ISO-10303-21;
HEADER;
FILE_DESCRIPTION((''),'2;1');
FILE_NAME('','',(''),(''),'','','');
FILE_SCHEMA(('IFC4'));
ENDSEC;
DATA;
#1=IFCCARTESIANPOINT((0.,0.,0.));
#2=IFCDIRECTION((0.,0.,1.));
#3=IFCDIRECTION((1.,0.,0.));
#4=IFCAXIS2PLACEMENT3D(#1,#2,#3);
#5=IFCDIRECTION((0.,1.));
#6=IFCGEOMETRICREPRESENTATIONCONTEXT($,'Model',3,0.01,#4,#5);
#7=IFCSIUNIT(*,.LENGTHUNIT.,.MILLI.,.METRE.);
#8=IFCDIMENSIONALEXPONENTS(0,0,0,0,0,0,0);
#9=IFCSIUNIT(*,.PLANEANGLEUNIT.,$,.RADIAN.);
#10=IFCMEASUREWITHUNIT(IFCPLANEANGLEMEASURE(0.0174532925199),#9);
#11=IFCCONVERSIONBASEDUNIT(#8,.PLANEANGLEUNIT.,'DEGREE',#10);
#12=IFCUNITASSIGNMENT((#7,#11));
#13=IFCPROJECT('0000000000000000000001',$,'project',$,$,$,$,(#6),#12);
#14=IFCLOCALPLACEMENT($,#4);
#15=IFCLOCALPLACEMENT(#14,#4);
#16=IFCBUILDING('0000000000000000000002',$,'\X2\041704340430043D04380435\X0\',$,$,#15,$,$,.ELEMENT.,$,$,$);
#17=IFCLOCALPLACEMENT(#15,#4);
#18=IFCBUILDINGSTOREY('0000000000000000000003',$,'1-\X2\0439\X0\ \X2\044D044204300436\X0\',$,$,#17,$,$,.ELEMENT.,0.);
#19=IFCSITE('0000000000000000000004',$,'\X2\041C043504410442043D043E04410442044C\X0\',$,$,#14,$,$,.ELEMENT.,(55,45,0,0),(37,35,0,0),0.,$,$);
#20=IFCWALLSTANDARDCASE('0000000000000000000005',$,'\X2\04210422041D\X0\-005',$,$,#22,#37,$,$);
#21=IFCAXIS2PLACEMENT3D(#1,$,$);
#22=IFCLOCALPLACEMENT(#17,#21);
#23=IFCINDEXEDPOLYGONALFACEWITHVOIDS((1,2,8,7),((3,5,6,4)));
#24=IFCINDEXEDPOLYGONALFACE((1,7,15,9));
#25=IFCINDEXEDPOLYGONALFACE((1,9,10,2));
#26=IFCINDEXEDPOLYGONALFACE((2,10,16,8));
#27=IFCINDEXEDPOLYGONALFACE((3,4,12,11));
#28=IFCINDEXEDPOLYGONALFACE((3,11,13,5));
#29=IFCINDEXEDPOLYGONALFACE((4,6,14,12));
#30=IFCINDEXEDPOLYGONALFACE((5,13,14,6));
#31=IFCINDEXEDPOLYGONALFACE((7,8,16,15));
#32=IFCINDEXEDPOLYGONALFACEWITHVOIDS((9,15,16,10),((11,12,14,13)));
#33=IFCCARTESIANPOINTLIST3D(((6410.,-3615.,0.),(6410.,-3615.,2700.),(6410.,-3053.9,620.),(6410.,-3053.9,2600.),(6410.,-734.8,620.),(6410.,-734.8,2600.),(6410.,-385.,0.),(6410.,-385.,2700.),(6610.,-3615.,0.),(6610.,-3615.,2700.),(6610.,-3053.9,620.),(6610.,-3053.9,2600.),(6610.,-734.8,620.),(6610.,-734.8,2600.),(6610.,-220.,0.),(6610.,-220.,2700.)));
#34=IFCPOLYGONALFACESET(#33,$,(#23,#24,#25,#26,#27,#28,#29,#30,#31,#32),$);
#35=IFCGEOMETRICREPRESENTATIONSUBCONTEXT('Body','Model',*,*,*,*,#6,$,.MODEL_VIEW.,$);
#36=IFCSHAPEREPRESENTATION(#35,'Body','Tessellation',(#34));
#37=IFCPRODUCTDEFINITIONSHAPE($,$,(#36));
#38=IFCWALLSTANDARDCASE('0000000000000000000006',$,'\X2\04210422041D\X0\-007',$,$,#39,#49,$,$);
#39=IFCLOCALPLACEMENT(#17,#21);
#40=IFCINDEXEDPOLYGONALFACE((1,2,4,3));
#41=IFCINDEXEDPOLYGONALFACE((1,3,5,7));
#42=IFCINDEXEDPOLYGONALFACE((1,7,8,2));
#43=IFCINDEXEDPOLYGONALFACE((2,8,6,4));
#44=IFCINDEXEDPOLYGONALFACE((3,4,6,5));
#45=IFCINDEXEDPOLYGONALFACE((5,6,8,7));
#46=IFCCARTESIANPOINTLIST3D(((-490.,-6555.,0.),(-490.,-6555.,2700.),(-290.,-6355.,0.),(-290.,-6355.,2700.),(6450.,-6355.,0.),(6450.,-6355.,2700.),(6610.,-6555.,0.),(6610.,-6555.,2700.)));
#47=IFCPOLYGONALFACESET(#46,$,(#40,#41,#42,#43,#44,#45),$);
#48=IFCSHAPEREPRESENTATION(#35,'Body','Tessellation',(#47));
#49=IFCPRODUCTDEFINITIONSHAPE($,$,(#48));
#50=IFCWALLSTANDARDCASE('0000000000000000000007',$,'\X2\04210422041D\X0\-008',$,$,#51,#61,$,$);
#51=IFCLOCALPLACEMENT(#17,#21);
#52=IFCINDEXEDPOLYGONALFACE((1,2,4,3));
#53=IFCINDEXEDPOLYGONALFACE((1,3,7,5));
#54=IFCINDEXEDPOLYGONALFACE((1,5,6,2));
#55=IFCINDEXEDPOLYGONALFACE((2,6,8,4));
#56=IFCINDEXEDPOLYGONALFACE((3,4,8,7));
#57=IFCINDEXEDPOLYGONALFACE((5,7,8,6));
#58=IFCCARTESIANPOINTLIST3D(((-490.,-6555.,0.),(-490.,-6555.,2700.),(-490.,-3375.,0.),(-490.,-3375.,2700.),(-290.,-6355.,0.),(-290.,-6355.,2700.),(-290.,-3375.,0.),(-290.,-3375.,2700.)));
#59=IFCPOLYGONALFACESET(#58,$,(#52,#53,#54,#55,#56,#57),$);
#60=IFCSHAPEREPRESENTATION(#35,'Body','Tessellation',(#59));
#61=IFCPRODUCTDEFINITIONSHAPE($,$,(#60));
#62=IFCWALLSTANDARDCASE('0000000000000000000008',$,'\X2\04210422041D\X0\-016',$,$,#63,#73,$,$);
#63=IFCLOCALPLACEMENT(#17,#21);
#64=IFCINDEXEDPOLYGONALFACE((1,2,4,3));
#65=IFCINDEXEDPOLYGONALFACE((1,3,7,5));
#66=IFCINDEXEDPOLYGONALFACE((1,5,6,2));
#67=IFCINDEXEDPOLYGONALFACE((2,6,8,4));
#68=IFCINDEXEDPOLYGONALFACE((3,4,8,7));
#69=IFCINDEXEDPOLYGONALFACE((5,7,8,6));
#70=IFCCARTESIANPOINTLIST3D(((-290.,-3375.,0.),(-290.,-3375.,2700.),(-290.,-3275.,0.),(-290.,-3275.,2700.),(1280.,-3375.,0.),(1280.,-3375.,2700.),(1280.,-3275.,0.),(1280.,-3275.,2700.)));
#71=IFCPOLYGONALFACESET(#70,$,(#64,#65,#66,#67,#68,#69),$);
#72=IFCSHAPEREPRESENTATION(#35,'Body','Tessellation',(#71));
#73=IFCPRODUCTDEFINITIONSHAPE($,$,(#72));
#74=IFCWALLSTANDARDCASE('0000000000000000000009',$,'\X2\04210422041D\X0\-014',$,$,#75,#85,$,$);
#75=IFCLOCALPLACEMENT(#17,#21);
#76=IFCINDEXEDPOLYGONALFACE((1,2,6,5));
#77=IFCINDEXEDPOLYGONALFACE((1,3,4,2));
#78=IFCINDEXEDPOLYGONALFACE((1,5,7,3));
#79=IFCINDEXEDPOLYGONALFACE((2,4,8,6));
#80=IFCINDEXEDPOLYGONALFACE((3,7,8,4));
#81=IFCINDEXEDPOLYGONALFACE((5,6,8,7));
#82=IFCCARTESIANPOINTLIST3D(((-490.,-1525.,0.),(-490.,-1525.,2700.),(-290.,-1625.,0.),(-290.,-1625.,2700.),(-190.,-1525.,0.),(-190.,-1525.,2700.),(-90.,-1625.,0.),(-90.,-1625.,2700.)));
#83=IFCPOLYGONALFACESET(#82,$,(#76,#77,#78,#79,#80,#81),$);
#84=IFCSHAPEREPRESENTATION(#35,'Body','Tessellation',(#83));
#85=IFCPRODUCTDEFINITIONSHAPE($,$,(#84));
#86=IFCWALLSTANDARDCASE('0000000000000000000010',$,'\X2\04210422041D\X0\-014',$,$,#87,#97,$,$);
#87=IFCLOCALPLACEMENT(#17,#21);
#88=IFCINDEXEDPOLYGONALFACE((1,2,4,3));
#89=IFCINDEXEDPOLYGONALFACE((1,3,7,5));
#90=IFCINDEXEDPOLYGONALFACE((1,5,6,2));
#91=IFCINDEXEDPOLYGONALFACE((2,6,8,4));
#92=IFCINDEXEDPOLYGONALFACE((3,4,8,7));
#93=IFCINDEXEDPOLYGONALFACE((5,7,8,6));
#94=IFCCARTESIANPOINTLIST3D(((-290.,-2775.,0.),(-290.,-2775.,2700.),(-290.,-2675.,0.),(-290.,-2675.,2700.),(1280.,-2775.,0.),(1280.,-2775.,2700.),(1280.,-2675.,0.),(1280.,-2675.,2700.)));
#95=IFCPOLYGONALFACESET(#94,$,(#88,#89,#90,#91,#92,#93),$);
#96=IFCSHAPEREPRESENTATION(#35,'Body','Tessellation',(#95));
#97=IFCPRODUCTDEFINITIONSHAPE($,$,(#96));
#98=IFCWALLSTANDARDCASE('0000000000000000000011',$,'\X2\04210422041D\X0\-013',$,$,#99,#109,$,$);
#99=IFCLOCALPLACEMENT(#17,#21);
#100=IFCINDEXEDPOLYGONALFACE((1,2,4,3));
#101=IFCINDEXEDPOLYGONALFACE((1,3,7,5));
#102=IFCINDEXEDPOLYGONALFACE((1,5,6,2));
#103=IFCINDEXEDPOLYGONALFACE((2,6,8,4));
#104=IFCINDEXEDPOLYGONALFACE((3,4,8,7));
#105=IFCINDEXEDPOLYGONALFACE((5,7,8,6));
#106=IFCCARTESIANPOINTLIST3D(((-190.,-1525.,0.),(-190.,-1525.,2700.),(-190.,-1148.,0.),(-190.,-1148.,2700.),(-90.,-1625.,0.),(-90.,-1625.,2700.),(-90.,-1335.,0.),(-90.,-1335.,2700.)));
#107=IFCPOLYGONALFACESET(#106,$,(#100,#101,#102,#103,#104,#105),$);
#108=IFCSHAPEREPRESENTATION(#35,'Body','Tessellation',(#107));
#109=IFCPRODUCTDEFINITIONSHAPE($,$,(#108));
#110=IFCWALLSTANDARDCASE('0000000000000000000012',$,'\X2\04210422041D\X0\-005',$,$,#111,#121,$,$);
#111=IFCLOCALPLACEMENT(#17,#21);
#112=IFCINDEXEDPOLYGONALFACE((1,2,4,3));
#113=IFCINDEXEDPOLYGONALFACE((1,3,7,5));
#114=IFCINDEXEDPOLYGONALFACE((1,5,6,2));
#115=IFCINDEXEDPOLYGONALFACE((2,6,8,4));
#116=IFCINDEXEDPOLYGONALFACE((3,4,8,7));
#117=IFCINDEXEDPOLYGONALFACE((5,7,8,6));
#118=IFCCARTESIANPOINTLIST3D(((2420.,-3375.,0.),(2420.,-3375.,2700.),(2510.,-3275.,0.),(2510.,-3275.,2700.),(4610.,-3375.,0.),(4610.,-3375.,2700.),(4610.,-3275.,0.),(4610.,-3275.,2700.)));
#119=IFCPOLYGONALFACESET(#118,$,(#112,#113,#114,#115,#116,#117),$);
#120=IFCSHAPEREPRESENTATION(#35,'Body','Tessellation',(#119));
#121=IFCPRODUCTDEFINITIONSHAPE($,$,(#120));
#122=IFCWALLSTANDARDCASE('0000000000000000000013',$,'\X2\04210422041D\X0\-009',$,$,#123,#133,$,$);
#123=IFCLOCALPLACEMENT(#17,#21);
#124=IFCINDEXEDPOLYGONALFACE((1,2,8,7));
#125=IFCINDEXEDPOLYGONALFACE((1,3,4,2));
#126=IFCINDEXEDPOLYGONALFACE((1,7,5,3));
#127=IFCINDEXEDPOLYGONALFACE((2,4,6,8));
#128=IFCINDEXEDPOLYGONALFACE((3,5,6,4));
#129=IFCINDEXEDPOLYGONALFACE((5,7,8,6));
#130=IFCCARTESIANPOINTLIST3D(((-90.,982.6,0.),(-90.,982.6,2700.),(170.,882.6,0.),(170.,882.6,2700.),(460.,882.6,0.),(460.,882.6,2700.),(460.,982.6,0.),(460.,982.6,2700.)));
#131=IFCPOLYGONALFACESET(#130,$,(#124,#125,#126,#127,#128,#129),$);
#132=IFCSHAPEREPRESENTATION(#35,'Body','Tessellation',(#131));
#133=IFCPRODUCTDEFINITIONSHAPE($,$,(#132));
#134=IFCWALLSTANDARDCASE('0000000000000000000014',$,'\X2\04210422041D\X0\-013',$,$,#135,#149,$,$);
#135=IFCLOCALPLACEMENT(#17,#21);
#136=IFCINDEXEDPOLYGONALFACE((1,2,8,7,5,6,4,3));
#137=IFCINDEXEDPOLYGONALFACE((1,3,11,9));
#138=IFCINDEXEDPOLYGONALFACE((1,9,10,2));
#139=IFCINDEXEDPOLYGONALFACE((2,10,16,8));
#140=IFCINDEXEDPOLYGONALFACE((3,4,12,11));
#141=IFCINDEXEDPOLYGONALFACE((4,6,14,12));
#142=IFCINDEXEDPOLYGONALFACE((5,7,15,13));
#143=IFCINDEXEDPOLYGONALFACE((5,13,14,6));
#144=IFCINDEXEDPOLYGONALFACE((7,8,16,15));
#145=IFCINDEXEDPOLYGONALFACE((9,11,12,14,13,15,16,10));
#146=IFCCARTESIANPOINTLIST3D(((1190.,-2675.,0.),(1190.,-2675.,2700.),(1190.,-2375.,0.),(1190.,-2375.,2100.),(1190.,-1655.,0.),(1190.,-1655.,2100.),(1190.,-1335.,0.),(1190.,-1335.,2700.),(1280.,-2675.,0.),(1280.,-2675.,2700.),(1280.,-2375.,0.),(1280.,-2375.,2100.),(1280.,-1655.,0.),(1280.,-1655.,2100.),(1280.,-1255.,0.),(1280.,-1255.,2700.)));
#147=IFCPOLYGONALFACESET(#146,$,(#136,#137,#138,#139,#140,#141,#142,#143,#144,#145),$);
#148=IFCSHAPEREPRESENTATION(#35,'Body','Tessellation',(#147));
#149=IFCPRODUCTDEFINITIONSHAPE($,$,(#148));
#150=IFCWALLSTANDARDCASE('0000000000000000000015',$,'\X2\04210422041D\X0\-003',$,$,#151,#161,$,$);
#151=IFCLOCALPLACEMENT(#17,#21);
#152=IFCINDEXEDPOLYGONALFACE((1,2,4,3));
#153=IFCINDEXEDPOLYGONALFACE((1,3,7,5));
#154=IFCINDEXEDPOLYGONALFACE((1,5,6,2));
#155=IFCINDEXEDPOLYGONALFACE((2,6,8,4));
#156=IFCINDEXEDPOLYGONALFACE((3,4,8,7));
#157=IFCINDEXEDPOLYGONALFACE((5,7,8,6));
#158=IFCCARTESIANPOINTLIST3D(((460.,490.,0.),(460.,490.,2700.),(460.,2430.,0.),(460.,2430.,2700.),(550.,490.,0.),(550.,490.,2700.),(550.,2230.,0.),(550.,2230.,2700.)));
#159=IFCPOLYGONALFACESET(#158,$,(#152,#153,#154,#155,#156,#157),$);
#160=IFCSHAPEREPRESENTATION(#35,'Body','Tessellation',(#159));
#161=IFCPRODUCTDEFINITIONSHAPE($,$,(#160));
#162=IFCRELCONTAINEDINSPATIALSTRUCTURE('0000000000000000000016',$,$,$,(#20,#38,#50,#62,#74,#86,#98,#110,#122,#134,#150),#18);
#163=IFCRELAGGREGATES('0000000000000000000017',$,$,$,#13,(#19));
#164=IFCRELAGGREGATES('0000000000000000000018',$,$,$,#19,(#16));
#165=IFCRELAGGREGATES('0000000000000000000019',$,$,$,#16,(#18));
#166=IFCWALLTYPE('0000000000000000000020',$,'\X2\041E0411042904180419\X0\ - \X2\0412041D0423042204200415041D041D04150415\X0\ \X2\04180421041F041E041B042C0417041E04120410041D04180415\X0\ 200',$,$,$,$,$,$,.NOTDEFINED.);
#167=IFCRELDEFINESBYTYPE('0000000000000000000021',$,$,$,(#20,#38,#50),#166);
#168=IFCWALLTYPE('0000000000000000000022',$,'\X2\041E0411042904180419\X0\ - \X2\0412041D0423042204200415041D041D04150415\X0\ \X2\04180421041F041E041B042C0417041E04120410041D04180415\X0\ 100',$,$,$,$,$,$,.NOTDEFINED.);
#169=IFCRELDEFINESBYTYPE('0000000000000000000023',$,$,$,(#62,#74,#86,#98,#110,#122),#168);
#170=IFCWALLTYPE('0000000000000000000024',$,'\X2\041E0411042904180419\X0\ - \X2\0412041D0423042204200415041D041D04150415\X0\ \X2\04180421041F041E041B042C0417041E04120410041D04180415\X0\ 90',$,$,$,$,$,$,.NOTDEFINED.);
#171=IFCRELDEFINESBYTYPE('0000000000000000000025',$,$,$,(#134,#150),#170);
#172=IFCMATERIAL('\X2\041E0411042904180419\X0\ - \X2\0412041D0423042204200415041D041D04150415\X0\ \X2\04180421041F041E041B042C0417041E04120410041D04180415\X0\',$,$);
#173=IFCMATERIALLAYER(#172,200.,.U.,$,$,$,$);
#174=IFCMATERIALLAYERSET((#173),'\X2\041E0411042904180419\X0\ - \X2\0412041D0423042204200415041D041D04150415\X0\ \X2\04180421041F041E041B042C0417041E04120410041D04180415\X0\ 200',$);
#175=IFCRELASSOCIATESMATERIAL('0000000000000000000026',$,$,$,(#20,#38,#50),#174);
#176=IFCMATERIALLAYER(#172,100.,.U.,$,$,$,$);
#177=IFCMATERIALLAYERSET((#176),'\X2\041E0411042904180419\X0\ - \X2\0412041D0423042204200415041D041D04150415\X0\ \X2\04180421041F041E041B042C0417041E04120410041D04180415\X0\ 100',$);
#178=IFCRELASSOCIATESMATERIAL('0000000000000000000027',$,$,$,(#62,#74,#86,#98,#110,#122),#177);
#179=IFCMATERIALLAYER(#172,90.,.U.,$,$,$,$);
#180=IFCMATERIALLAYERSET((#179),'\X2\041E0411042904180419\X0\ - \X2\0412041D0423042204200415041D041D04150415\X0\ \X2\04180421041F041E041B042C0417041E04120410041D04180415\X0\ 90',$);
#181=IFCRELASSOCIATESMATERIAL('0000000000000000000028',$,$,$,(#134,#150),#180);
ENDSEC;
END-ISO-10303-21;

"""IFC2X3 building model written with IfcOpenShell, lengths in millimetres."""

from ifc_helpers import new_model, entity, si_unit, converted_unit, direction, frame, origin_with_axes, origin_2d_with_axis, place, context, subcontext, project, spatial, polyline, rectangle, outline, extrude, material, layer, layer_set, layer_usage, type_object, element, save


model = new_model("IFC2X3")

# Units and contexts
model_context = context("Model", 3, precision=0.01, world=origin_with_axes(), true_north=direction((0.0, 1.0)))
body_context = subcontext(model_context, "Body", "Model", "MODEL_VIEW")
ifc_project = project(units=[si_unit("LENGTHUNIT", "METRE", prefix="MILLI"), converted_unit("PLANEANGLEUNIT", "DEGREE", entity("IfcPlaneAngleMeasure", 0.0174532925199), si_unit("PLANEANGLEUNIT", "RADIAN"), dimensions=[0, 0, 0, 0, 0, 0, 0])], contexts=[model_context])

# Site, building, storey
site_placement = place(None, origin_with_axes())
site = spatial("IfcSite", under=ifc_project, at=site_placement, Name="Местность", CompositionType="ELEMENT", RefLatitude=(55, 45, 0, 0), RefLongitude=(37, 35, 0, 0), RefElevation=0.0)
building_placement = place(site_placement, origin_with_axes())
building = spatial("IfcBuilding", under=site, at=building_placement, Name="Здание", CompositionType="ELEMENT")
storey_placement = place(building_placement, origin_with_axes())
storey = spatial("IfcBuildingStorey", under=building, at=storey_placement, Name="1-й этаж", CompositionType="ELEMENT", Elevation=0.0)

# Shared definitions
ifc_material = material(Name="ОБЩИЙ - ВНУТРЕННЕЕ ИСПОЛЬЗОВАНИЕ")

# Shared definitions
ifc_layer_1 = layer(ifc_material, 200.0, ventilated="UNKNOWN")
ifc_layer_set_1 = layer_set([ifc_layer_1], Name="ОБЩИЙ - ВНУТРЕННЕЕ ИСПОЛЬЗОВАНИЕ 200")
wall_type_1 = type_object("IfcWallType", Name="ОБЩИЙ - ВНУТРЕННЕЕ ИСПОЛЬЗОВАНИЕ 200", PredefinedType="NOTDEFINED")

# Wall, opening
ifc_layer_usage_1 = layer_usage(ifc_layer_set_1, "AXIS2", "POSITIVE", -200.0)
wall_1_placement = place(storey_placement, frame((6610.0, -220.0, 0.0), z_axis=(0.0, 0.0, 1.0), x_axis=(0.0, -1.0, 0.0)))
wall_1 = element("IfcWallStandardCase", 1, at=wall_1_placement, inside=storey, type_object=wall_type_1, material=ifc_layer_usage_1, Name="СТН-005", context=body_context, shape_type="SweptSolid", body=[
    extrude(outline(polyline([(165.0, -200.0), (3395.0, -200.0), (3395.0, 0.0), (0.0, 0.0), (165.0, -200.0)])), origin_with_axes(), (0.0, 0.0, 1.0), 2700.0),
])
opening_1_placement = place(wall_1_placement, frame((1674.3, 0.0, 620.0), z_axis=(0.0, 0.0, 1.0), x_axis=(1.0, 0.0, 0.0)))
element("IfcOpeningElement", 2, at=opening_1_placement, cuts=wall_1, context=body_context, shape_type="SweptSolid", body=[
    extrude(rectangle(XDim=2319.2, YDim=1980.0, at=origin_2d_with_axis()), frame((0.0, -200.0, 990.0), z_axis=(0.0, -1.0, 0.0), x_axis=(1.0, 0.0, 0.0)), (0.0, 0.0, -1.0), 600.0),
])

# Walls
ifc_layer_usage_2 = layer_usage(ifc_layer_set_1, "AXIS2", "POSITIVE", -200.0)
wall_2_placement = place(storey_placement, frame((6610.0, -6555.0, 0.0), z_axis=(0.0, 0.0, 1.0), x_axis=(-1.0, 0.0, 0.0)))
element("IfcWallStandardCase", 3, at=wall_2_placement, inside=storey, type_object=wall_type_1, material=ifc_layer_usage_2, Name="СТН-007", context=body_context, shape_type="SweptSolid", body=[
    extrude(outline(polyline([(160.0, -200.0), (6900.0, -200.0), (7100.0, 0.0), (0.0, 0.0), (160.0, -200.0)])), origin_with_axes(), (0.0, 0.0, 1.0), 2700.0),
])
ifc_layer_usage_3 = layer_usage(ifc_layer_set_1, "AXIS2", "POSITIVE", -200.0)
wall_3_placement = place(storey_placement, frame((-490.0, -6555.0, 0.0), z_axis=(0.0, 0.0, 1.0), x_axis=(0.0, 1.0, 0.0)))
element("IfcWallStandardCase", 4, at=wall_3_placement, inside=storey, type_object=wall_type_1, material=ifc_layer_usage_3, Name="СТН-008", context=body_context, shape_type="SweptSolid", body=[
    extrude(outline(polyline([(200.0, -200.0), (3180.0, -200.0), (3180.0, 0.0), (0.0, 0.0), (200.0, -200.0)])), origin_with_axes(), (0.0, 0.0, 1.0), 2700.0),
])
ifc_layer_2 = layer(ifc_material, 100.0, ventilated="UNKNOWN")
ifc_layer_set_2 = layer_set([ifc_layer_2], Name="ОБЩИЙ - ВНУТРЕННЕЕ ИСПОЛЬЗОВАНИЕ 100")
ifc_layer_usage_4 = layer_usage(ifc_layer_set_2, "AXIS2", "POSITIVE", -100.0)
wall_type_2 = type_object("IfcWallType", Name="ОБЩИЙ - ВНУТРЕННЕЕ ИСПОЛЬЗОВАНИЕ 100", PredefinedType="NOTDEFINED")
wall_4_placement = place(storey_placement, frame((1280.0, -3375.0, 0.0), z_axis=(0.0, 0.0, 1.0), x_axis=(-1.0, 0.0, 0.0)))
element("IfcWallStandardCase", 5, at=wall_4_placement, inside=storey, type_object=wall_type_2, material=ifc_layer_usage_4, Name="СТН-016", context=body_context, shape_type="SweptSolid", body=[
    extrude(outline(polyline([(0.0, -100.0), (1570.0, -100.0), (1570.0, 0.0), (0.0, 0.0), (0.0, -100.0)])), origin_with_axes(), (0.0, 0.0, 1.0), 2700.0),
])
ifc_layer_usage_5 = layer_usage(ifc_layer_set_2, "AXIS2", "POSITIVE", 0.0)
wall_5_placement = place(storey_placement, frame((-190.0, -1525.0, 0.0), z_axis=(0.0, 0.0, 1.0), x_axis=(-1.0, 0.0, 0.0)))
element("IfcWallStandardCase", 6, at=wall_5_placement, inside=storey, type_object=wall_type_2, material=ifc_layer_usage_5, Name="СТН-014", context=body_context, shape_type="SweptSolid", body=[
    extrude(outline(polyline([(0.0, 0.0), (300.0, 0.0), (100.0, 100.0), (-100.0, 100.0), (0.0, 0.0)])), origin_with_axes(), (0.0, 0.0, 1.0), 2700.0),
])
ifc_layer_usage_6 = layer_usage(ifc_layer_set_2, "AXIS2", "POSITIVE", 0.0)
wall_6_placement = place(storey_placement, frame((1280.0, -2675.0, 0.0), z_axis=(0.0, 0.0, 1.0), x_axis=(-1.0, 0.0, 0.0)))
element("IfcWallStandardCase", 7, at=wall_6_placement, inside=storey, type_object=wall_type_2, material=ifc_layer_usage_6, Name="СТН-014", context=body_context, shape_type="SweptSolid", body=[
    extrude(outline(polyline([(0.0, 0.0), (1570.0, 0.0), (1570.0, 100.0), (0.0, 100.0), (0.0, 0.0)])), origin_with_axes(), (0.0, 0.0, 1.0), 2700.0),
])
ifc_layer_usage_7 = layer_usage(ifc_layer_set_2, "AXIS2", "POSITIVE", 0.0)
wall_7_placement = place(storey_placement, frame((-190.0, -1335.0, 0.0), z_axis=(0.0, 0.0, 1.0), x_axis=(0.0, -1.0, 0.0)))
element("IfcWallStandardCase", 8, at=wall_7_placement, inside=storey, type_object=wall_type_2, material=ifc_layer_usage_7, Name="СТН-013", context=body_context, shape_type="SweptSolid", body=[
    extrude(outline(polyline([(-187.0, 0.0), (190.0, 0.0), (290.0, 100.0), (0.0, 100.0), (-187.0, 0.0)])), origin_with_axes(), (0.0, 0.0, 1.0), 2700.0),
])
ifc_layer_usage_8 = layer_usage(ifc_layer_set_2, "AXIS2", "POSITIVE", -100.0)
wall_8_placement = place(storey_placement, frame((2510.0, -3275.0, 0.0), z_axis=(0.0, 0.0, 1.0), x_axis=(1.0, 0.0, 0.0)))
element("IfcWallStandardCase", 9, at=wall_8_placement, inside=storey, type_object=wall_type_2, material=ifc_layer_usage_8, Name="СТН-005", context=body_context, shape_type="SweptSolid", body=[
    extrude(outline(polyline([(-90.0, -100.0), (2100.0, -100.0), (2100.0, 0.0), (0.0, 0.0), (-90.0, -100.0)])), origin_with_axes(), (0.0, 0.0, 1.0), 2700.0),
])
ifc_layer_usage_9 = layer_usage(ifc_layer_set_2, "AXIS2", "POSITIVE", 0.0)
wall_9_placement = place(storey_placement, frame((460.0, 982.6, 0.0), z_axis=(0.0, 0.0, 1.0), x_axis=(-1.0, 0.0, 0.0)))
element("IfcWallStandardCase", 10, at=wall_9_placement, inside=storey, type_object=wall_type_2, material=ifc_layer_usage_9, Name="СТН-009", context=body_context, shape_type="SweptSolid", body=[
    extrude(outline(polyline([(0.0, 0.0), (550.0, 0.0), (290.0, 100.0), (0.0, 100.0), (0.0, 0.0)])), origin_with_axes(), (0.0, 0.0, 1.0), 2700.0),
])

# Wall, opening
ifc_layer_3 = layer(ifc_material, 90.0, ventilated="UNKNOWN")
ifc_layer_set_3 = layer_set([ifc_layer_3], Name="ОБЩИЙ - ВНУТРЕННЕЕ ИСПОЛЬЗОВАНИЕ 90")
ifc_layer_usage_10 = layer_usage(ifc_layer_set_3, "AXIS2", "POSITIVE", 0.0)
wall_type_3 = type_object("IfcWallType", Name="ОБЩИЙ - ВНУТРЕННЕЕ ИСПОЛЬЗОВАНИЕ 90", PredefinedType="NOTDEFINED")
wall_10_placement = place(storey_placement, frame((1190.0, -1335.0, 0.0), z_axis=(0.0, 0.0, 1.0), x_axis=(0.0, -1.0, 0.0)))
wall_10 = element("IfcWallStandardCase", 11, at=wall_10_placement, inside=storey, type_object=wall_type_3, material=ifc_layer_usage_10, Name="СТН-013", context=body_context, shape_type="SweptSolid", body=[
    extrude(outline(polyline([(0.0, 0.0), (1340.0, 0.0), (1340.0, 90.0), (-80.0, 90.0), (0.0, 0.0)])), origin_with_axes(), (0.0, 0.0, 1.0), 2700.0),
])
opening_2_placement = place(wall_10_placement, frame((680.0, 0.0, 0.0), z_axis=(0.0, 0.0, 1.0), x_axis=(1.0, 0.0, 0.0)))
element("IfcOpeningElement", 12, at=opening_2_placement, cuts=wall_10, context=body_context, shape_type="SweptSolid", body=[
    extrude(rectangle(XDim=720.0, YDim=2100.0, at=origin_2d_with_axis()), frame((0.0, -90.0, 1050.0), z_axis=(0.0, -1.0, 0.0), x_axis=(1.0, 0.0, 0.0)), (0.0, 0.0, -1.0), 270.0),
])

# Wall
ifc_layer_usage_11 = layer_usage(ifc_layer_set_3, "AXIS2", "POSITIVE", 0.0)
wall_11_placement = place(storey_placement, frame((460.0, 2430.0, 0.0), z_axis=(0.0, 0.0, 1.0), x_axis=(0.0, -1.0, 0.0)))
element("IfcWallStandardCase", 13, at=wall_11_placement, inside=storey, type_object=wall_type_3, material=ifc_layer_usage_11, Name="СТН-003", context=body_context, shape_type="SweptSolid", body=[
    extrude(outline(polyline([(0.0, 0.0), (1940.0, 0.0), (1940.0, 90.0), (200.0, 90.0), (0.0, 0.0)])), origin_with_axes(), (0.0, 0.0, 1.0), 2700.0),
])

save(model, "model.ifc")
